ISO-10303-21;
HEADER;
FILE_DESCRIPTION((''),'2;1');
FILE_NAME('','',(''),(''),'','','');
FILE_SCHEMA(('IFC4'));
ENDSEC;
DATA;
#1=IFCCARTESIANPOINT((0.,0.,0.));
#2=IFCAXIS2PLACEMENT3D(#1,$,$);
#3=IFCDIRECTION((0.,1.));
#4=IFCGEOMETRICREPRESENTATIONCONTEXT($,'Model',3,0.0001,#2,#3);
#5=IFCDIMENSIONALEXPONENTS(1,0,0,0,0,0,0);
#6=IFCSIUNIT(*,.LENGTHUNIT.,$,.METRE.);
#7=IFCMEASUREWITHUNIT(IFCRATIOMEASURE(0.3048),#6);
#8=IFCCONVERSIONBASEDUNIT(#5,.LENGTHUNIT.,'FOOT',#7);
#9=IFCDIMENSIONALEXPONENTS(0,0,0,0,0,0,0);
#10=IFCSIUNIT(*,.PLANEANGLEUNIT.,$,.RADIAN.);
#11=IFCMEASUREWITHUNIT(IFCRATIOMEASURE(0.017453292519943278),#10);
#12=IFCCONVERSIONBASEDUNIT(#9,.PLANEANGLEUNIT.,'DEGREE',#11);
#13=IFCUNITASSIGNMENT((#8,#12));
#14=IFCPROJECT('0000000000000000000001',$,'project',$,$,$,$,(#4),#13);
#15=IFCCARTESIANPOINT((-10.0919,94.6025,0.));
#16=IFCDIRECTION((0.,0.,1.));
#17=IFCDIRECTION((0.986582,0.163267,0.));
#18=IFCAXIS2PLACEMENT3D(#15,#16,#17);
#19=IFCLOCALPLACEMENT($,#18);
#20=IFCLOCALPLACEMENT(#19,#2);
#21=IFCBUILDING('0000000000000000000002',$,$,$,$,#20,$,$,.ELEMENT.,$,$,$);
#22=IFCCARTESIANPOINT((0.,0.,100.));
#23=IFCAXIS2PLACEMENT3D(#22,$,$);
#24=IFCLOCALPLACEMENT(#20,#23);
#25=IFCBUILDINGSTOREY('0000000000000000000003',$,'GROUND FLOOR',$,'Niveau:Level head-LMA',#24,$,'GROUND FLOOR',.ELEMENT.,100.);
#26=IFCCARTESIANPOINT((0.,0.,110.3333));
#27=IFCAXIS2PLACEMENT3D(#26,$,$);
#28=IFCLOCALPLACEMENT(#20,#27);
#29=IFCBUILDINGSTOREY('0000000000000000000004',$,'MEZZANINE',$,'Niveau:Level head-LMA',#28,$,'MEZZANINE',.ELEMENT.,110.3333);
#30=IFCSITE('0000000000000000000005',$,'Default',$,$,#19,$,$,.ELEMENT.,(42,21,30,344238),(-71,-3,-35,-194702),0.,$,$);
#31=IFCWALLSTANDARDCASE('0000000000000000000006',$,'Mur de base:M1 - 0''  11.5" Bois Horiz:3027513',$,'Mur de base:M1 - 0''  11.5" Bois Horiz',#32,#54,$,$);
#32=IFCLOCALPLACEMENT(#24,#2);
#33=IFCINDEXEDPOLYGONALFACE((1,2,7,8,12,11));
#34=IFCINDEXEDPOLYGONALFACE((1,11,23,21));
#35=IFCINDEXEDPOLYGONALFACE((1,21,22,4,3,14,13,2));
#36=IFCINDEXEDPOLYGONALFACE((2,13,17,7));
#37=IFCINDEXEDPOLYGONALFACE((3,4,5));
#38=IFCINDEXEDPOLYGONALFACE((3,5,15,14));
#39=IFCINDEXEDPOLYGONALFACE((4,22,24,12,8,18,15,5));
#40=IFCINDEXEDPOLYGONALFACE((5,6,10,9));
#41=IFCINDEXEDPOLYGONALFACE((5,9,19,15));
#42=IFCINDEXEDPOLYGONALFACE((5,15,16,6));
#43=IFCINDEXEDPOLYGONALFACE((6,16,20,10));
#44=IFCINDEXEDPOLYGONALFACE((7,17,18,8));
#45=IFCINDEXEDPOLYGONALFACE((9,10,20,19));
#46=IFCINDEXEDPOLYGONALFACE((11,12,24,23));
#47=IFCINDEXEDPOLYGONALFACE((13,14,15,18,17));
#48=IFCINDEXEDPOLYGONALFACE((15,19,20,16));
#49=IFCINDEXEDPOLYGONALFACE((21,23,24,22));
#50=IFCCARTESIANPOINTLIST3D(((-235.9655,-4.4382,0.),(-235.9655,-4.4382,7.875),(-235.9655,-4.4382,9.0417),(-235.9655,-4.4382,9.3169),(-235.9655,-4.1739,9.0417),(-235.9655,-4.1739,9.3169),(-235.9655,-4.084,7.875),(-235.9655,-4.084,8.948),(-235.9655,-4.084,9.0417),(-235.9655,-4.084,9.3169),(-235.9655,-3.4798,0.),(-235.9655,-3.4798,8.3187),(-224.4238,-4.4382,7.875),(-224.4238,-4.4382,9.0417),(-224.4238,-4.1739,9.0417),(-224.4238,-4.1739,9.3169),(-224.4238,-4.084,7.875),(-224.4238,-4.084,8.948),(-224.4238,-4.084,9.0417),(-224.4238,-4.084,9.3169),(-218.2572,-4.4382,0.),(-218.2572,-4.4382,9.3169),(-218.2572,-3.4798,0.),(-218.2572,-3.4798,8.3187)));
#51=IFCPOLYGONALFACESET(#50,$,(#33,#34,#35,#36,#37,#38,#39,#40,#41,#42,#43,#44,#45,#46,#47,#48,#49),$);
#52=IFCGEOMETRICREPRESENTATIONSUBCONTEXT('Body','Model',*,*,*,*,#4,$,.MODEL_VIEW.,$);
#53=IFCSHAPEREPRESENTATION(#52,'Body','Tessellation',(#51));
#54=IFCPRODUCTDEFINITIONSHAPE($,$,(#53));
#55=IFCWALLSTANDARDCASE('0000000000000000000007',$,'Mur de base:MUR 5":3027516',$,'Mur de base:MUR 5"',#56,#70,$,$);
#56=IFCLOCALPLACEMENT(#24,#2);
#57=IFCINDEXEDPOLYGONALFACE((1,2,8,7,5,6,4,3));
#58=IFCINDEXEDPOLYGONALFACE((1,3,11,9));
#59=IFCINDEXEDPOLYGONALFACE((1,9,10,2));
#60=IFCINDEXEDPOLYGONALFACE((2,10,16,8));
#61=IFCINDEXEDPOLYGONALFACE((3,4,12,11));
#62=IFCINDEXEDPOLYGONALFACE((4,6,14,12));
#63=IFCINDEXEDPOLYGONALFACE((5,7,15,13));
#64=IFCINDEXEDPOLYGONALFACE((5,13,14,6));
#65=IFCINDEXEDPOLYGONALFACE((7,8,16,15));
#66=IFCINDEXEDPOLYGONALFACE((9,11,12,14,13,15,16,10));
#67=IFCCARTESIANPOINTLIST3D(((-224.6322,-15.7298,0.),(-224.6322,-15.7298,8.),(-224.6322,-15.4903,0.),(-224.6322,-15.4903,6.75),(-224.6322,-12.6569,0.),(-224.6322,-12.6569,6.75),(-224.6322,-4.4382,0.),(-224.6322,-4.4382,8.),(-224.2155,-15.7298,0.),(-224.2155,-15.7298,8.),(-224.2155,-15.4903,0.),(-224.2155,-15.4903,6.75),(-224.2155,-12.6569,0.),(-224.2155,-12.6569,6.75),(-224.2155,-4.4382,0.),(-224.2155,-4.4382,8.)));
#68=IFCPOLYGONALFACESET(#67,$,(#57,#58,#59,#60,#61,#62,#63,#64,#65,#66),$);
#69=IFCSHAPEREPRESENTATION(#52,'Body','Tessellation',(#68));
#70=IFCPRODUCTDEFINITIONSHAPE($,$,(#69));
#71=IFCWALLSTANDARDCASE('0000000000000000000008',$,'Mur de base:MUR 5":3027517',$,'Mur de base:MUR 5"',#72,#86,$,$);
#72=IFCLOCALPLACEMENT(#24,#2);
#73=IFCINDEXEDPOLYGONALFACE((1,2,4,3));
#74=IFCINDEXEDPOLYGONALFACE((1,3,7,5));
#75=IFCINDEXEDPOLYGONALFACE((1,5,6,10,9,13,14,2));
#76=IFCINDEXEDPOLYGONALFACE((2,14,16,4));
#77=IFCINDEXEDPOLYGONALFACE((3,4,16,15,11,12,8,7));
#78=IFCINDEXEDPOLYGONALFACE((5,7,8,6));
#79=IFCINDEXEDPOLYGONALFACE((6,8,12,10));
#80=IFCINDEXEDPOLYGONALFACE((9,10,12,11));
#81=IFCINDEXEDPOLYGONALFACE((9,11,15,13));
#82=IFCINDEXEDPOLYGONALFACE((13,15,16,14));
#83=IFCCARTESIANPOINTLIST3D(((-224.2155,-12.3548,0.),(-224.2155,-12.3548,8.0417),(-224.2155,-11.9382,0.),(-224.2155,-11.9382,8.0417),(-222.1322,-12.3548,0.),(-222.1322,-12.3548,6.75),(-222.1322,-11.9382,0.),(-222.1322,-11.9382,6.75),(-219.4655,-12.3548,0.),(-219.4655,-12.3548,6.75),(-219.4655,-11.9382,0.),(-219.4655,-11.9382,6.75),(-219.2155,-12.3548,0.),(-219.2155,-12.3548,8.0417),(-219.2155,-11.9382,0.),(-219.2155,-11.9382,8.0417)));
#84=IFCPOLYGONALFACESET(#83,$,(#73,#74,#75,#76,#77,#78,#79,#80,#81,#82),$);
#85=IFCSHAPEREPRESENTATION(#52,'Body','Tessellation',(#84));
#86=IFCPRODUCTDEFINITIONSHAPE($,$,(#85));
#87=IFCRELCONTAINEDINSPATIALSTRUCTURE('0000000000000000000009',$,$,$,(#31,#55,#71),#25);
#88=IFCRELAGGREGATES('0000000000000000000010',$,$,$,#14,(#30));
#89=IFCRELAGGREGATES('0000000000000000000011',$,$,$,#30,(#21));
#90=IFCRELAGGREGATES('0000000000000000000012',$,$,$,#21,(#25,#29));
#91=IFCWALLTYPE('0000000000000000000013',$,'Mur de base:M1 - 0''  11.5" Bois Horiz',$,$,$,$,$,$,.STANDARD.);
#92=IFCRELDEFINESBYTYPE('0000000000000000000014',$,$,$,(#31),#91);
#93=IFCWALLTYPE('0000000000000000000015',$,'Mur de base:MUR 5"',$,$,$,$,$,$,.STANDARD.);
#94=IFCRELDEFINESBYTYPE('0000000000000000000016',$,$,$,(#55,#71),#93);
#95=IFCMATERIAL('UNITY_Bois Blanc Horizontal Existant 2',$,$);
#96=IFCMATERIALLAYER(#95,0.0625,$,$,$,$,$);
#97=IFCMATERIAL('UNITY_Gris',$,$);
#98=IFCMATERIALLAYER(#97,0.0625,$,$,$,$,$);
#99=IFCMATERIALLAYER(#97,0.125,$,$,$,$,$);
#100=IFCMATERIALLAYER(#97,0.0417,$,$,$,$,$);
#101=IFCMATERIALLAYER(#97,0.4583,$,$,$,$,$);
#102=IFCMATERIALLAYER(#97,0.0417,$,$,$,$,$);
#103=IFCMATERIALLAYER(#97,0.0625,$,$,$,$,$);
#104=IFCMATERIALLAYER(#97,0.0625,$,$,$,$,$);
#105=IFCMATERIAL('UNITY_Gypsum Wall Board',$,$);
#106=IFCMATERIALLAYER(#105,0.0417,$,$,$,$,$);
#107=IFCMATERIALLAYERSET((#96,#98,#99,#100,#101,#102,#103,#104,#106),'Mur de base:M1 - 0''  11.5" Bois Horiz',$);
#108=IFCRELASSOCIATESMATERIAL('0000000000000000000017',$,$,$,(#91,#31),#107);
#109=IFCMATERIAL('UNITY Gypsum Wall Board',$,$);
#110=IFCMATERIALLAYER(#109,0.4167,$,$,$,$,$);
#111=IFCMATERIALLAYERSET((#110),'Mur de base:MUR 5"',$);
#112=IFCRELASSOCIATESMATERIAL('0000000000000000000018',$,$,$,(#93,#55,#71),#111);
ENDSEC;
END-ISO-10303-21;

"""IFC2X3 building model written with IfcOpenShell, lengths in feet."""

from ifc_helpers import new_model, entity, si_unit, converted_unit, direction, frame, frame_2d, origin, place, context, subcontext, project, spatial, polyline, rectangle, extrude, clip, bounded_halfspace, material, layer, layer_set, layer_usage, type_object, element, save


model = new_model("IFC2X3")

# Units and contexts
model_context = context("Model", 3, precision=0.0001, world=origin(), true_north=direction((0.0, 1.0)))
body_context = subcontext(model_context, "Body", "Model", "MODEL_VIEW")
ifc_project = project(units=[converted_unit("LENGTHUNIT", "FOOT", entity("IfcRatioMeasure", 0.3048), si_unit("LENGTHUNIT", "METRE"), dimensions=[1, 0, 0, 0, 0, 0, 0]), converted_unit("PLANEANGLEUNIT", "DEGREE", entity("IfcRatioMeasure", 0.017453292519943278), si_unit("PLANEANGLEUNIT", "RADIAN"), dimensions=[0, 0, 0, 0, 0, 0, 0])], contexts=[model_context])

# Site, building, storey
site_placement = place(None, frame((-10.0919, 94.6025, 0.0), z_axis=(0.0, 0.0, 1.0), x_axis=(0.986582, 0.163267, 0.0)))
site = spatial("IfcSite", under=ifc_project, at=site_placement, Name="Default", CompositionType="ELEMENT", RefLatitude=(42, 21, 30, 344238), RefLongitude=(-71, -3, -35, -194702), RefElevation=0.0)
building_placement = place(site_placement, origin())
building = spatial("IfcBuilding", under=site, at=building_placement, CompositionType="ELEMENT")
storey_1_placement = place(building_placement, frame((0.0, 0.0, 100.0)))
storey_1 = spatial("IfcBuildingStorey", under=building, at=storey_1_placement, Name="GROUND FLOOR", ObjectType="Niveau:Level head-LMA", LongName="GROUND FLOOR", CompositionType="ELEMENT", Elevation=100.0)

# Shared definitions
ifc_material_1 = material(Name="UNITY_Gris")

# Shared definitions
ifc_material_2 = material(Name="UNITY_Bois Blanc Horizontal Existant 2")
ifc_layer_1 = layer(ifc_material_2, 0.0625)
ifc_layer_2 = layer(ifc_material_1, 0.0625)
ifc_layer_3 = layer(ifc_material_1, 0.125)
ifc_layer_4 = layer(ifc_material_1, 0.0417)
ifc_layer_5 = layer(ifc_material_1, 0.4583)
ifc_layer_6 = layer(ifc_material_1, 0.0417)
ifc_layer_7 = layer(ifc_material_1, 0.0625)
ifc_layer_8 = layer(ifc_material_1, 0.0625)
ifc_material_3 = material(Name="UNITY_Gypsum Wall Board")
ifc_layer_9 = layer(ifc_material_3, 0.0417)
ifc_layer_set_1 = layer_set([ifc_layer_1, ifc_layer_2, ifc_layer_3, ifc_layer_4, ifc_layer_5, ifc_layer_6, ifc_layer_7, ifc_layer_8, ifc_layer_9], Name="Mur de base:M1 - 0'  11.5\" Bois Horiz")
wall_type_1 = type_object("IfcWallType", Name="Mur de base:M1 - 0'  11.5\" Bois Horiz", PredefinedType="STANDARD", material=ifc_layer_set_1)

# Shared definitions
storey_2_placement = place(building_placement, frame((0.0, 0.0, 110.3333)))
storey_2 = spatial("IfcBuildingStorey", under=building, at=storey_2_placement, Name="MEZZANINE", ObjectType="Niveau:Level head-LMA", LongName="MEZZANINE", CompositionType="ELEMENT", Elevation=110.3333)

# Walls, openings
ifc_layer_usage_1 = layer_usage(ifc_layer_set_1, "AXIS2", "NEGATIVE", 0.4792)
wall_1_placement = place(storey_1_placement, frame((-235.9655, -3.959, 0.0)))
wall_1 = element("IfcWallStandardCase", 1, at=wall_1_placement, inside=storey_1, type_object=wall_type_1, material=ifc_layer_usage_1, Name="Mur de base:M1 - 0'  11.5\" Bois Horiz:3027513", ObjectType="Mur de base:M1 - 0'  11.5\" Bois Horiz", context=body_context, shape_type="Clipping", body=[
    clip(extrude(rectangle(XDim=17.7083, YDim=0.9583, at=frame_2d((8.8542, 0.0), x_axis=(-1.0, 0.0))), origin(), (0.0, 0.0, 1.0), 9.3169), bounded_halfspace(frame((0.0, -0.4792, 9.3169), z_axis=(0.0, 0.721387, 0.692532), x_axis=(-1.0, 0.0, 0.0)), False, frame((0.0, -0.4792, 9.3169)), polyline([(0.0, 0.0), (11.3333, 0.0), (11.75, 0.0), (16.75, 0.0), (17.7083, 0.0), (17.7083, 0.9583), (0.0, 0.9583), (0.0, 0.3542), (11.5417, 0.3542), (11.5417, 0.2643), (0.0, 0.2643), (0.0, 0.0)]))),
])
opening_1_placement = place(storey_1_placement, frame((-235.9655, -3.959, 0.0)))
element("IfcOpeningElement", 2, at=opening_1_placement, cuts=wall_1, ObjectType="Opening", context=body_context, shape_type="SweptSolid", body=[
    extrude(rectangle(XDim=0.3542, YDim=11.5417, at=frame_2d((0.0, 0.0), x_axis=(1.0, 0.0))), frame((5.7708, -0.3021, 7.875), z_axis=(0.0, 0.0, 1.0), x_axis=(0.0, 1.0, 0.0)), (0.0, 0.0, 1.0), 1.1667),
])
ifc_material_4 = material(Name="UNITY Gypsum Wall Board")
ifc_layer_10 = layer(ifc_material_4, 0.4167)
ifc_layer_set_2 = layer_set([ifc_layer_10], Name="Mur de base:MUR 5\"")
ifc_layer_usage_2 = layer_usage(ifc_layer_set_2, "AXIS2", "NEGATIVE", 0.2083)
wall_type_2 = type_object("IfcWallType", Name="Mur de base:MUR 5\"", PredefinedType="STANDARD", material=ifc_layer_set_2)
wall_2_placement = place(storey_1_placement, frame((-224.4238, -15.7298, 0.0), z_axis=(0.0, 0.0, 1.0), x_axis=(0.0, 1.0, 0.0)))
wall_2 = element("IfcWallStandardCase", 3, at=wall_2_placement, inside=storey_1, type_object=wall_type_2, material=ifc_layer_usage_2, Name="Mur de base:MUR 5\":3027516", ObjectType="Mur de base:MUR 5\"", context=body_context, shape_type="SweptSolid", body=[
    extrude(rectangle(XDim=11.2917, YDim=0.4167, at=frame_2d((5.6458, 0.0), x_axis=(-1.0, 0.0))), origin(), (0.0, 0.0, 1.0), 8.0),
])
opening_2_placement = place(wall_2_placement, frame((15.7298, -224.4238, 0.0), z_axis=(0.0, 0.0, 1.0), x_axis=(0.0, -1.0, 0.0)))
element("IfcOpeningElement", 4, at=opening_2_placement, cuts=wall_2, ObjectType="Opening", context=body_context, shape_type="SweptSolid", body=[
    extrude(rectangle(XDim=6.75, YDim=2.8333, at=frame_2d((0.0, 0.0), x_axis=(1.0, 0.0))), frame((-219.2155, -14.0736, 3.375), z_axis=(-1.0, 0.0, 0.0), x_axis=(0.0, 0.0, 1.0)), (0.0, 0.0, 1.0), 10.0),
])
ifc_layer_usage_3 = layer_usage(ifc_layer_set_2, "AXIS2", "POSITIVE", -0.2083)
wall_3_placement = place(storey_1_placement, frame((-224.2155, -12.1465, 0.0)))
wall_3 = element("IfcWallStandardCase", 5, at=wall_3_placement, inside=storey_1, type_object=wall_type_2, material=ifc_layer_usage_3, Name="Mur de base:MUR 5\":3027517", ObjectType="Mur de base:MUR 5\"", context=body_context, shape_type="SweptSolid", body=[
    extrude(rectangle(XDim=5.0, YDim=0.4167, at=frame_2d((2.5, 0.0), x_axis=(-1.0, 0.0))), origin(), (0.0, 0.0, 1.0), 8.0417),
])
opening_3_placement = place(wall_3_placement, frame((224.2155, 12.1465, 0.0)))
element("IfcOpeningElement", 6, at=opening_3_placement, cuts=wall_3, ObjectType="Opening", context=body_context, shape_type="SweptSolid", body=[
    extrude(rectangle(XDim=6.75, YDim=2.6667, at=frame_2d((0.0, 0.0), x_axis=(0.0, 1.0))), frame((-220.7988, -17.3548, 3.375), z_axis=(0.0, 1.0, 0.0), x_axis=(-1.0, 0.0, 0.0)), (0.0, 0.0, 1.0), 10.0),
])

save(model, "model.ifc")
